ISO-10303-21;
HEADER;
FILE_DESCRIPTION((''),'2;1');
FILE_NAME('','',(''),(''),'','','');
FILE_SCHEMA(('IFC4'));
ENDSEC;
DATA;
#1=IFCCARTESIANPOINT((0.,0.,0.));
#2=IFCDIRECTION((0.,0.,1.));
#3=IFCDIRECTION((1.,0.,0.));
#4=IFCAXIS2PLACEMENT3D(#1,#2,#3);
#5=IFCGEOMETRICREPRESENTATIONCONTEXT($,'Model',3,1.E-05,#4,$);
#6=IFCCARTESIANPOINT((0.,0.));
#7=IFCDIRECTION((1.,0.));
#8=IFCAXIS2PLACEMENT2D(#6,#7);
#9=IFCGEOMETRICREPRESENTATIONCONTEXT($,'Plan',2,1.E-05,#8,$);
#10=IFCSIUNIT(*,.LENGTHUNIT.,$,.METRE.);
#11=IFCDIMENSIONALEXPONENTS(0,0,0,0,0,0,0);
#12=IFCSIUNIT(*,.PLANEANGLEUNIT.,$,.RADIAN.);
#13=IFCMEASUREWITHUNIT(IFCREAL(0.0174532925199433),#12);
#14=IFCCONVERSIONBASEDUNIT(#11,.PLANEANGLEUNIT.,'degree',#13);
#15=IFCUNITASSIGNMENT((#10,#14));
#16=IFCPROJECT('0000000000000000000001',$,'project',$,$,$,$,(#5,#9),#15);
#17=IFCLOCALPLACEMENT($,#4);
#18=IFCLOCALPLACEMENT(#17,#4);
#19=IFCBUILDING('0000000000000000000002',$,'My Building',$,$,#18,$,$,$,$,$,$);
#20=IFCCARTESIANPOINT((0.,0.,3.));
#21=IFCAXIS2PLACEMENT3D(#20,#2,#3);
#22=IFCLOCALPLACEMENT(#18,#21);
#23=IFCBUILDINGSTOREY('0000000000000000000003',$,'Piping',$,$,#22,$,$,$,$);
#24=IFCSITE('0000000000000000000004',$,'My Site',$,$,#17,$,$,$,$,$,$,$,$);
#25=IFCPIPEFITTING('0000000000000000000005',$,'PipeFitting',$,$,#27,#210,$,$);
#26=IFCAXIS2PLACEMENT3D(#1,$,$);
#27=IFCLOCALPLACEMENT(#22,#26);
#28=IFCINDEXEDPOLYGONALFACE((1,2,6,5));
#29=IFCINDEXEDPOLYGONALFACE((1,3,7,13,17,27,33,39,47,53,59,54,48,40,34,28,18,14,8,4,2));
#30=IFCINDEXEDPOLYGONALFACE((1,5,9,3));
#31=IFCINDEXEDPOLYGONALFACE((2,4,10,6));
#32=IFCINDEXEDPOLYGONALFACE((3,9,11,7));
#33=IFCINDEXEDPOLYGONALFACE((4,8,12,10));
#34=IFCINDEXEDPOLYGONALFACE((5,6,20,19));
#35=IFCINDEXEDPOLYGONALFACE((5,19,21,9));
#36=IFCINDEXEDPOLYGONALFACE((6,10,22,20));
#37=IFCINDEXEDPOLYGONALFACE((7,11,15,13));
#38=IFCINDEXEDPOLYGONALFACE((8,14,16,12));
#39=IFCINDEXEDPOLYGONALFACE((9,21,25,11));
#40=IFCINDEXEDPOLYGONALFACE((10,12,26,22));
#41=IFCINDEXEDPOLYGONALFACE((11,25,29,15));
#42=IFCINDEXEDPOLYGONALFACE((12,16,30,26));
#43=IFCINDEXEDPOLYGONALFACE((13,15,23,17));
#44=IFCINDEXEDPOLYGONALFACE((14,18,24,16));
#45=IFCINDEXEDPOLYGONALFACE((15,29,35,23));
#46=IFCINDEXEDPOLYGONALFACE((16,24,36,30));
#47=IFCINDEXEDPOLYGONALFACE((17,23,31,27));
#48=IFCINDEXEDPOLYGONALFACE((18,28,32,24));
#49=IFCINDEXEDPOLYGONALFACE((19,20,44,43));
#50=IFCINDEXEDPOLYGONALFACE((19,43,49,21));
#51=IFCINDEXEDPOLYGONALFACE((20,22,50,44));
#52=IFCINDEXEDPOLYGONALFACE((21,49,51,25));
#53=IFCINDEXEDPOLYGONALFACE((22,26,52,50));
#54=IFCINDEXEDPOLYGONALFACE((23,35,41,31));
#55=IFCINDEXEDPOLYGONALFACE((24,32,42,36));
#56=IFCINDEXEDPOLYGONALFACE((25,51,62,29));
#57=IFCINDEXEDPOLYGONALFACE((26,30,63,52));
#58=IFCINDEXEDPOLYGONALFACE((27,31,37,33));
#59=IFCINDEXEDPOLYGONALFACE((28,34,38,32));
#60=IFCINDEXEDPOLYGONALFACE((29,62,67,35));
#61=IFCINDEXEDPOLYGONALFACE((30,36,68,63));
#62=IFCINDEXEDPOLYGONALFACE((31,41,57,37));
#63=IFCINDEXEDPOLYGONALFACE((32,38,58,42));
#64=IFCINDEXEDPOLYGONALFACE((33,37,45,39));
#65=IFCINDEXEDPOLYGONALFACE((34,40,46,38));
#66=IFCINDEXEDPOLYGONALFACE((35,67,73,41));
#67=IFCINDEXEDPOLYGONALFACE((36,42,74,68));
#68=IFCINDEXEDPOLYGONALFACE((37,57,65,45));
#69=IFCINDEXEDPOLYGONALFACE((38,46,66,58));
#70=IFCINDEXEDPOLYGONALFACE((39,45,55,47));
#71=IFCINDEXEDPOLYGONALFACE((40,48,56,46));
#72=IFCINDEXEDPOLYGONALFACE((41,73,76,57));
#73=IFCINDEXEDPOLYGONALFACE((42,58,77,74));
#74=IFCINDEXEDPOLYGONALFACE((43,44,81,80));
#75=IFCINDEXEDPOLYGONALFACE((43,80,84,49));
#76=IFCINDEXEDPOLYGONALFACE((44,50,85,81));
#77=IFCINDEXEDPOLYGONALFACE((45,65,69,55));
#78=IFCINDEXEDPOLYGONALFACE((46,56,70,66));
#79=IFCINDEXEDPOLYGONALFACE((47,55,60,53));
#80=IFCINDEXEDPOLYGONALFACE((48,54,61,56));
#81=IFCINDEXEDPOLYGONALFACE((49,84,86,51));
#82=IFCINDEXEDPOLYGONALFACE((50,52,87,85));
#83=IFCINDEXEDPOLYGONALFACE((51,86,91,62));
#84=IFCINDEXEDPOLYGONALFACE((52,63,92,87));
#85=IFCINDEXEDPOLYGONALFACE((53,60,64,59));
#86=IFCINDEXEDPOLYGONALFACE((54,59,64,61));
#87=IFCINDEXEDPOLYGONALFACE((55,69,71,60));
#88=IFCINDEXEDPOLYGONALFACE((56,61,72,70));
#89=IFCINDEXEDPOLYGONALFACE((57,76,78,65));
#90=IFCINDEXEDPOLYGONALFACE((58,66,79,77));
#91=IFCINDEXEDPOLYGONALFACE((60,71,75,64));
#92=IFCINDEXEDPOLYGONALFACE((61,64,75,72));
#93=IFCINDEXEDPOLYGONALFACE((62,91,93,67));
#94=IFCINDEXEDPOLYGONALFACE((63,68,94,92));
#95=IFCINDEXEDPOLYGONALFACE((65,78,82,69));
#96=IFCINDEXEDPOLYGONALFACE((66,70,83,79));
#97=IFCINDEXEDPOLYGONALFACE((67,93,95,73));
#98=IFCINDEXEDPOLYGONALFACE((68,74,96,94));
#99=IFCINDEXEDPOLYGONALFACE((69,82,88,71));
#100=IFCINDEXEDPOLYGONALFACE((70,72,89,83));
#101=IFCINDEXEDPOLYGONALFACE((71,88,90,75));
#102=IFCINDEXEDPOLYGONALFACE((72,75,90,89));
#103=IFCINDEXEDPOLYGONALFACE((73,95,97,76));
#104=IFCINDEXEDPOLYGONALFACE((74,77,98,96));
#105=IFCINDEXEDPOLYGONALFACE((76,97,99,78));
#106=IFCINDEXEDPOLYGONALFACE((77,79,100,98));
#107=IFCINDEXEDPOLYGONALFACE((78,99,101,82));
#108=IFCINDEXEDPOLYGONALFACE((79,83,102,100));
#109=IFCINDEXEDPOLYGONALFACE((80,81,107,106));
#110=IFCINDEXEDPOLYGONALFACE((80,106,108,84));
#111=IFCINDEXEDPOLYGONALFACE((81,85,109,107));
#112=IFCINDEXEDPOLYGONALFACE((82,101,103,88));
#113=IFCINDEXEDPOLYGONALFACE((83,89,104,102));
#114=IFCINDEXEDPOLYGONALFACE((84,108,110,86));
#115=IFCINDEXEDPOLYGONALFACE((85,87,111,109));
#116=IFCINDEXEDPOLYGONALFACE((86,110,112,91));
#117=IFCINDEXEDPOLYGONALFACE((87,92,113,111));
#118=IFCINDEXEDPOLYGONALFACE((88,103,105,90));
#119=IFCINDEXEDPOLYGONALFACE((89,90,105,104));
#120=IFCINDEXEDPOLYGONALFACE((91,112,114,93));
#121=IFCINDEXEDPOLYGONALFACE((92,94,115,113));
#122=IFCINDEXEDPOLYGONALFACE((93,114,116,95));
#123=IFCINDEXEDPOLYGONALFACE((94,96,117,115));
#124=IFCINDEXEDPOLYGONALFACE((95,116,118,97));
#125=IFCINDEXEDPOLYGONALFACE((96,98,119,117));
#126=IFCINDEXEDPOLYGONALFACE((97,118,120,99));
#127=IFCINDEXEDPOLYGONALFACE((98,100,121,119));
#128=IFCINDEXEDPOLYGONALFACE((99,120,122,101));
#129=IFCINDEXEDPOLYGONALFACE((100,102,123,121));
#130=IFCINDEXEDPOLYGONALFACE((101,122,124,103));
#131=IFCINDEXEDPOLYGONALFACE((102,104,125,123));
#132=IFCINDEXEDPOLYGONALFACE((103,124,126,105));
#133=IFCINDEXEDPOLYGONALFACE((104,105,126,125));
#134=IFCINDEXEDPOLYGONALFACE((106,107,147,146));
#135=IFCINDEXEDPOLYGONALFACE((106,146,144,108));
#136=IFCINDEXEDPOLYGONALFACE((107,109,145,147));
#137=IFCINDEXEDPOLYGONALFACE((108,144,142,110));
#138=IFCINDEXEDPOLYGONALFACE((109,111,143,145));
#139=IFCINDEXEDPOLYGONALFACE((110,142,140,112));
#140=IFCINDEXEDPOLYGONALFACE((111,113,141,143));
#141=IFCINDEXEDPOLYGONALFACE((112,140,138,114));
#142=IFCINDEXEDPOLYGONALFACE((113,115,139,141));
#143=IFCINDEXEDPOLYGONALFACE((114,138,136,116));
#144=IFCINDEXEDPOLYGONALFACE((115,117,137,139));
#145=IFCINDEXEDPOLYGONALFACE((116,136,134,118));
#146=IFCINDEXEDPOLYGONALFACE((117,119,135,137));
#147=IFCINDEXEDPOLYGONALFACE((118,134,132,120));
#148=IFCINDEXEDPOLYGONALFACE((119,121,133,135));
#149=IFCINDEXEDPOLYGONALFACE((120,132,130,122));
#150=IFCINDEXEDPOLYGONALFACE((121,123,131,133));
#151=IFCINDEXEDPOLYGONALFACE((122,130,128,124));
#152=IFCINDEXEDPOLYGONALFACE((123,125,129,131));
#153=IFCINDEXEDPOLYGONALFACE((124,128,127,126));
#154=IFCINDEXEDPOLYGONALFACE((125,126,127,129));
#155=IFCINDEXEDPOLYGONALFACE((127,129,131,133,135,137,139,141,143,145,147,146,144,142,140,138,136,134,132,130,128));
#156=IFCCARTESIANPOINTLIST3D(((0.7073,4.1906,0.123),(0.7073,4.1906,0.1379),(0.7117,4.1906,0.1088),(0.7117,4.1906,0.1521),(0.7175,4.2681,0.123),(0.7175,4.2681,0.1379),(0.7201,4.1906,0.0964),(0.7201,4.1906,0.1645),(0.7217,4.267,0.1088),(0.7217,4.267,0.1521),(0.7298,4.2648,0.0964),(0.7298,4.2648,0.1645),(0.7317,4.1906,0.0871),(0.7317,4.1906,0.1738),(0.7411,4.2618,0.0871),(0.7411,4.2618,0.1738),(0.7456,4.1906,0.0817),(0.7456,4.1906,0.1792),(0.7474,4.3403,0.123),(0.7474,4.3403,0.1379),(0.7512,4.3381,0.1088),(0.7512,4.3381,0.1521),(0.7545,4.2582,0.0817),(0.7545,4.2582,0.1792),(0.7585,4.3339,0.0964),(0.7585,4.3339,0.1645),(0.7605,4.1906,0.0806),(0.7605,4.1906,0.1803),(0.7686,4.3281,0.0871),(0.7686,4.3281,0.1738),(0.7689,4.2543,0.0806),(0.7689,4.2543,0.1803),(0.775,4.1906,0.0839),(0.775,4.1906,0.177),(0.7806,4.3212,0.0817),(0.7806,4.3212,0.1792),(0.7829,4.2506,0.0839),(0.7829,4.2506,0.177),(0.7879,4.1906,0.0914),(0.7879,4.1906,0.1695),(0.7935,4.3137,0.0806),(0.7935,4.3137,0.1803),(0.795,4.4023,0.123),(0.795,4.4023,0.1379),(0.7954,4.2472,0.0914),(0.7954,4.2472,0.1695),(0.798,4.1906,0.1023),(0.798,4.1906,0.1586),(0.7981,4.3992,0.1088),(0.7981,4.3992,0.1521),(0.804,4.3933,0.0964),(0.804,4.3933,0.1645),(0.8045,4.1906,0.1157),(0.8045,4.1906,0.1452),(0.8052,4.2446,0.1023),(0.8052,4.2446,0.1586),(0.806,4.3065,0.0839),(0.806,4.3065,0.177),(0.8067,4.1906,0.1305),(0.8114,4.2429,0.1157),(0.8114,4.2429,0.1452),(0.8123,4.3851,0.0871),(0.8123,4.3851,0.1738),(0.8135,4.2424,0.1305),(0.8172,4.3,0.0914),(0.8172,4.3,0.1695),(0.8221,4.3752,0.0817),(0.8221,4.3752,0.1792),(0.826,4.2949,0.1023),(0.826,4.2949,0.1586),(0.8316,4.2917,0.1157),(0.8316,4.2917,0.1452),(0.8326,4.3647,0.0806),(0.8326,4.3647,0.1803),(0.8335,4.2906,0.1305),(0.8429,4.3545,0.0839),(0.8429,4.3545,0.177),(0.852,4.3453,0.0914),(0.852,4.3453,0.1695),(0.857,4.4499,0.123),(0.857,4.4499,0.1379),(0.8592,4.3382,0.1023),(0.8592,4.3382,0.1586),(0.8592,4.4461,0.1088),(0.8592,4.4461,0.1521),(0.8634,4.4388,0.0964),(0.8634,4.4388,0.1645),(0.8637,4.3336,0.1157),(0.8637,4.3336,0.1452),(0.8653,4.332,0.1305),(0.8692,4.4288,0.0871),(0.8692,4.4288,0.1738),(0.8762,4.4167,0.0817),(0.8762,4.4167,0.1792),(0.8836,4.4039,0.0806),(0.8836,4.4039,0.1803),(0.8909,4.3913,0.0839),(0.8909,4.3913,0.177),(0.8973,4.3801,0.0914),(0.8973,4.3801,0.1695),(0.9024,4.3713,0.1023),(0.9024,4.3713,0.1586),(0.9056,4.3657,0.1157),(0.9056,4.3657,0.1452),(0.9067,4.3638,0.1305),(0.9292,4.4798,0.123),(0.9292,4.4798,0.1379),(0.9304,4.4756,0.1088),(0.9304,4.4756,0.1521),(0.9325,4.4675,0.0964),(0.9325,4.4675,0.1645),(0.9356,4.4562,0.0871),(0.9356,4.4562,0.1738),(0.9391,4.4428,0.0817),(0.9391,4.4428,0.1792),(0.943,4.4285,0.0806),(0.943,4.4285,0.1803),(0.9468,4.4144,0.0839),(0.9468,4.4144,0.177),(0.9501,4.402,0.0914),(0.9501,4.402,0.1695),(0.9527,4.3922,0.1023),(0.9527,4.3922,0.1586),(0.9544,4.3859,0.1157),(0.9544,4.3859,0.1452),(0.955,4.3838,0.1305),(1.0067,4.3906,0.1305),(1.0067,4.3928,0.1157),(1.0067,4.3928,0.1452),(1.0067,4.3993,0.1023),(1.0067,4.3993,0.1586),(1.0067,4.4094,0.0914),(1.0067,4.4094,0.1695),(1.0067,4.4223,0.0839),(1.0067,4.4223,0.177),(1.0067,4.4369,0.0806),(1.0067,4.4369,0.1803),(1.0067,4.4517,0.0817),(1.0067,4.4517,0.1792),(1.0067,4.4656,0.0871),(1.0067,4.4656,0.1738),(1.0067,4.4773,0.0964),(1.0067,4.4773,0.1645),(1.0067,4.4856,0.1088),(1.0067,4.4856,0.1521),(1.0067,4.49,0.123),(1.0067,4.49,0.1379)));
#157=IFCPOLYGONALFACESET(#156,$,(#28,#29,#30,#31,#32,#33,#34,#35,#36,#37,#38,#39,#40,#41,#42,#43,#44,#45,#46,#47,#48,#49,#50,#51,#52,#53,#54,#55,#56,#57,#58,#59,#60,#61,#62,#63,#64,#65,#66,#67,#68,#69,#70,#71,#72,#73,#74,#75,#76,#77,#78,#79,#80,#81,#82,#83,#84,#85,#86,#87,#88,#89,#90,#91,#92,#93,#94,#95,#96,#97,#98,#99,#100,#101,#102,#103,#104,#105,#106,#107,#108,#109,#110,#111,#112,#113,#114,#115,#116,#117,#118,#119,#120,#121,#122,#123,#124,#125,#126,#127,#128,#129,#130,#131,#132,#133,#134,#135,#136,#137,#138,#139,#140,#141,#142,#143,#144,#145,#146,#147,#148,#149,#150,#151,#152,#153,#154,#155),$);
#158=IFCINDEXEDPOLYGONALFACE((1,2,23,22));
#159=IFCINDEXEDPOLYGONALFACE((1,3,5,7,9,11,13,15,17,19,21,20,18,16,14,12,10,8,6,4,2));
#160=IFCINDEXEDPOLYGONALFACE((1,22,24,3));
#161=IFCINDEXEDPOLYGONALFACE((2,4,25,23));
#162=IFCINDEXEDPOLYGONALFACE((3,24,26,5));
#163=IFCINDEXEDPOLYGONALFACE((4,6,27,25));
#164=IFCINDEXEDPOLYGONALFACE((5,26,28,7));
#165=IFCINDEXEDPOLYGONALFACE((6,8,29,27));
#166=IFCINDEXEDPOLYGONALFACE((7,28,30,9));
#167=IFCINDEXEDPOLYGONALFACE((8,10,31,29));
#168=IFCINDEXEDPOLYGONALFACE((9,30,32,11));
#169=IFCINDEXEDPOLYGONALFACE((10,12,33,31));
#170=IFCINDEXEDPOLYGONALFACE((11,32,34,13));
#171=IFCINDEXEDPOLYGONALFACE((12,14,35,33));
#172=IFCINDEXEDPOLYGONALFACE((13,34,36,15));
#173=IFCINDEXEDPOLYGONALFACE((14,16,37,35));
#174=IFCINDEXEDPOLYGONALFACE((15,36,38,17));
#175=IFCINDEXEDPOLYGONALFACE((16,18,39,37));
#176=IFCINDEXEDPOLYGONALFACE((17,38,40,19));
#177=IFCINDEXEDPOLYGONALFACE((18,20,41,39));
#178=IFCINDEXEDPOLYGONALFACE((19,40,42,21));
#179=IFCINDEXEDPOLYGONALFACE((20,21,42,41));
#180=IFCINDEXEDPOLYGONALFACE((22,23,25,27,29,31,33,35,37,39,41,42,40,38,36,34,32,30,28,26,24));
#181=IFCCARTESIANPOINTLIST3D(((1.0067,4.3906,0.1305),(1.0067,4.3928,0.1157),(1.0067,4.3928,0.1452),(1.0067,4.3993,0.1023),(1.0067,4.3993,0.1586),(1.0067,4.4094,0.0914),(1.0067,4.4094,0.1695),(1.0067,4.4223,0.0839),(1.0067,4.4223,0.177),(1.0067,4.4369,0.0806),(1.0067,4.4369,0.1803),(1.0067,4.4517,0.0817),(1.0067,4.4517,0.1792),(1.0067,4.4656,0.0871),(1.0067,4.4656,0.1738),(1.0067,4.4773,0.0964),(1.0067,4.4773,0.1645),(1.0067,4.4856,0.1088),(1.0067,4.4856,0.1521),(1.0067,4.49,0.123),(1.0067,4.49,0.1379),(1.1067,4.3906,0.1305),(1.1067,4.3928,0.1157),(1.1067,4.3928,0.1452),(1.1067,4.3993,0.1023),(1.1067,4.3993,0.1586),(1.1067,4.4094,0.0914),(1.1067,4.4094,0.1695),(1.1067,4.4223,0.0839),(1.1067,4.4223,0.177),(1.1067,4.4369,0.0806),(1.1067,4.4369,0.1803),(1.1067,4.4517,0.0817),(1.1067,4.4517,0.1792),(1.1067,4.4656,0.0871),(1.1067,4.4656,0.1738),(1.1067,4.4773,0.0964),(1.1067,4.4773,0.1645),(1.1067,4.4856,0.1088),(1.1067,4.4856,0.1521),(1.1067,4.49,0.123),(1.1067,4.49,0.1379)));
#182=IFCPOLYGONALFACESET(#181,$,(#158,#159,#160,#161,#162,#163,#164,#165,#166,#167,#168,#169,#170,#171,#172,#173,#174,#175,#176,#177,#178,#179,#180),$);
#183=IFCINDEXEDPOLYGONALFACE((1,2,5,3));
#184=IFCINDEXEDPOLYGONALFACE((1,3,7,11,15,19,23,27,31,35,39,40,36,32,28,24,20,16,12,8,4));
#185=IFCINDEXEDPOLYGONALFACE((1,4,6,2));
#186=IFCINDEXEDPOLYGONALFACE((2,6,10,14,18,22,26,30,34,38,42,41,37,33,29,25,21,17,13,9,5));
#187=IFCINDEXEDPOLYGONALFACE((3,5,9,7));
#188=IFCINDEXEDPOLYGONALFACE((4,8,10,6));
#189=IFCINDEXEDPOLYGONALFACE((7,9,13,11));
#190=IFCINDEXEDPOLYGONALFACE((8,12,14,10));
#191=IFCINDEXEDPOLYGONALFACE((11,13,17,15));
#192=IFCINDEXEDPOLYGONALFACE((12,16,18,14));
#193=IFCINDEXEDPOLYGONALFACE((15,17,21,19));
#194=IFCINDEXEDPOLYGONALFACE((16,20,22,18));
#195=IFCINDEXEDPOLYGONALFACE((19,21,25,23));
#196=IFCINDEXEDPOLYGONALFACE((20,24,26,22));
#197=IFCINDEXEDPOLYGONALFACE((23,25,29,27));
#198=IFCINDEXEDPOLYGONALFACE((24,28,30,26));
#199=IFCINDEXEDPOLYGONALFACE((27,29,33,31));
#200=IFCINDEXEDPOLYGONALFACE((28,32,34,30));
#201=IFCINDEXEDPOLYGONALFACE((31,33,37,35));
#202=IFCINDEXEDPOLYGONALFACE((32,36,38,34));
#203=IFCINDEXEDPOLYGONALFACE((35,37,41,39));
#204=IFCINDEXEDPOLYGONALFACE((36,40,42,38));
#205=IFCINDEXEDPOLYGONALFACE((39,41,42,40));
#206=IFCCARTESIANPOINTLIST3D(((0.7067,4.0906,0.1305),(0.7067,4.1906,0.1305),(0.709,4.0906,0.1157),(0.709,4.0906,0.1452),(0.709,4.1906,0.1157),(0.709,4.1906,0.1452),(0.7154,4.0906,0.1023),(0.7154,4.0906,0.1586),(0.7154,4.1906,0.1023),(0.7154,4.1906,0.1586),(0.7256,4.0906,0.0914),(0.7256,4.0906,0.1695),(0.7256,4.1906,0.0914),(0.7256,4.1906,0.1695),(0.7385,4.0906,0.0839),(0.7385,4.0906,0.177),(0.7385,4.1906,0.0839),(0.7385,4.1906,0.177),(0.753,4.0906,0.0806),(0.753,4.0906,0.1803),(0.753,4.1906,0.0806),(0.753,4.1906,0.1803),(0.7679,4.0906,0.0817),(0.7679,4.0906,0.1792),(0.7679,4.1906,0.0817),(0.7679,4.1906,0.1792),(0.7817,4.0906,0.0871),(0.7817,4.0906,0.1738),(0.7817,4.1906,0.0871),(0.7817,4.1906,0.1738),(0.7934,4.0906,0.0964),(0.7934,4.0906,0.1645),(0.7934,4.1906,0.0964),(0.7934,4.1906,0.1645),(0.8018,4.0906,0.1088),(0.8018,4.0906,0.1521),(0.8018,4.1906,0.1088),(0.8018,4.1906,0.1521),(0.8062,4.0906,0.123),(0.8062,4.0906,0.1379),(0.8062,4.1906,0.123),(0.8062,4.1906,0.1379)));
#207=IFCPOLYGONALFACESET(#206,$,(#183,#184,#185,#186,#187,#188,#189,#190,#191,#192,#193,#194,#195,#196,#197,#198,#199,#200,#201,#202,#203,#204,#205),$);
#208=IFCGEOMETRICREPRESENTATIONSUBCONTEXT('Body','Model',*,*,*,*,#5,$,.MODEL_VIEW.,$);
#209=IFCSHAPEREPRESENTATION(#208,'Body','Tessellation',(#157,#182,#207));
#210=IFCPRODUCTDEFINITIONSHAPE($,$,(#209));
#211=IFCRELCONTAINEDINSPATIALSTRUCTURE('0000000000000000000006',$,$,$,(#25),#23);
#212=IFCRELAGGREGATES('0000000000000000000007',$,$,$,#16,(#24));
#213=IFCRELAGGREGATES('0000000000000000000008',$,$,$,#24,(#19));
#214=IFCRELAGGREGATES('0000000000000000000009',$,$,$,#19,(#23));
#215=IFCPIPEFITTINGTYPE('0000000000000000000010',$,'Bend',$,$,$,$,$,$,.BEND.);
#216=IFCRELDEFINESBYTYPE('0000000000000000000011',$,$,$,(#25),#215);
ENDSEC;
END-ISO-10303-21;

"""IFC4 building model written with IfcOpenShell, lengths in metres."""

from ifc_helpers import new_model, entity, si_unit, converted_unit, frame, origin_with_axes, origin_2d_with_axis, place, context, subcontext, project, spatial, circle, extrude, source, transform, mapped, type_object, type_shapes, element, save


model = new_model("IFC4")

# Units and contexts
model_context = context("Model", 3, precision=1e-05, world=origin_with_axes())
plan_context = context("Plan", 2, precision=1e-05, world=origin_2d_with_axis())
body_context = subcontext(model_context, "Body", "Model", "MODEL_VIEW")
ifc_project = project(units=[si_unit("LENGTHUNIT", "METRE"), converted_unit("PLANEANGLEUNIT", "degree", entity("IfcReal", 0.0174532925199433), si_unit("PLANEANGLEUNIT", "RADIAN"), dimensions=[0, 0, 0, 0, 0, 0, 0])], contexts=[model_context, plan_context])

# Site, building, storey
site_placement = place(None, origin_with_axes())
site = spatial("IfcSite", under=ifc_project, at=site_placement, Name="My Site")
building_placement = place(site_placement, origin_with_axes())
building = spatial("IfcBuilding", under=site, at=building_placement, Name="My Building")
storey_placement = place(building_placement, frame((0.0, 0.0, 3.0), z_axis=(0.0, 0.0, 1.0), x_axis=(1.0, 0.0, 0.0)))
storey = spatial("IfcBuildingStorey", under=building, at=storey_placement, Name="Piping")

# Pipe fitting
pipe_fitting_type_1 = type_object("IfcPipeFittingType", Name="Bend", PredefinedType="BEND")
shared_shape_1 = source(origin_with_axes(), body_context, "Body", "SolidModel", [
    entity("IfcSweptDiskSolid", entity("IfcIndexedPolyCurve", entity("IfcCartesianPointList3D", [[0.0, 0.0, 0.1], [0.0732, 0.0, 0.2768], [0.25, 0.0, 0.35]]), [entity("IfcArcIndex", [1, 2, 3])]), 0.05),
    extrude(circle(Radius=0.05), origin_with_axes(), (0.0, 0.0, 1.0), 0.1),
    extrude(circle(Radius=0.05), frame((0.25, 0.0, 0.35), z_axis=(1.0, 0.0, 0.000001), x_axis=(-0.000001, 0.0, 1.0)), (0.0, 0.0, 1.0), 0.1),
])
type_shapes(pipe_fitting_type_1, [shared_shape_1])
for number, where, z_axis, x_axis, name in (
    (1, (1.1067, 4.4406, 0.1305), (-1.0, -0.000001, 0.000001), (0.000001, -1.0, 0.0), "PipeFitting"),
):
    element("IfcPipeFitting", number, at=place(storey_placement, frame(where, z_axis=z_axis, x_axis=x_axis)), inside=storey, type_object=pipe_fitting_type_1, Name=name, context=body_context, shape_type="MappedRepresentation", body=[
        mapped(shared_shape_1, transform((0.0, 0.0, 0.0), x_axis=(1.0, 0.0, 0.0), y_axis=(0.0, 1.0, 0.0), z_axis=(0.0, 0.0, 1.0), scale=1.0)),
    ])

save(model, "model.ifc")
